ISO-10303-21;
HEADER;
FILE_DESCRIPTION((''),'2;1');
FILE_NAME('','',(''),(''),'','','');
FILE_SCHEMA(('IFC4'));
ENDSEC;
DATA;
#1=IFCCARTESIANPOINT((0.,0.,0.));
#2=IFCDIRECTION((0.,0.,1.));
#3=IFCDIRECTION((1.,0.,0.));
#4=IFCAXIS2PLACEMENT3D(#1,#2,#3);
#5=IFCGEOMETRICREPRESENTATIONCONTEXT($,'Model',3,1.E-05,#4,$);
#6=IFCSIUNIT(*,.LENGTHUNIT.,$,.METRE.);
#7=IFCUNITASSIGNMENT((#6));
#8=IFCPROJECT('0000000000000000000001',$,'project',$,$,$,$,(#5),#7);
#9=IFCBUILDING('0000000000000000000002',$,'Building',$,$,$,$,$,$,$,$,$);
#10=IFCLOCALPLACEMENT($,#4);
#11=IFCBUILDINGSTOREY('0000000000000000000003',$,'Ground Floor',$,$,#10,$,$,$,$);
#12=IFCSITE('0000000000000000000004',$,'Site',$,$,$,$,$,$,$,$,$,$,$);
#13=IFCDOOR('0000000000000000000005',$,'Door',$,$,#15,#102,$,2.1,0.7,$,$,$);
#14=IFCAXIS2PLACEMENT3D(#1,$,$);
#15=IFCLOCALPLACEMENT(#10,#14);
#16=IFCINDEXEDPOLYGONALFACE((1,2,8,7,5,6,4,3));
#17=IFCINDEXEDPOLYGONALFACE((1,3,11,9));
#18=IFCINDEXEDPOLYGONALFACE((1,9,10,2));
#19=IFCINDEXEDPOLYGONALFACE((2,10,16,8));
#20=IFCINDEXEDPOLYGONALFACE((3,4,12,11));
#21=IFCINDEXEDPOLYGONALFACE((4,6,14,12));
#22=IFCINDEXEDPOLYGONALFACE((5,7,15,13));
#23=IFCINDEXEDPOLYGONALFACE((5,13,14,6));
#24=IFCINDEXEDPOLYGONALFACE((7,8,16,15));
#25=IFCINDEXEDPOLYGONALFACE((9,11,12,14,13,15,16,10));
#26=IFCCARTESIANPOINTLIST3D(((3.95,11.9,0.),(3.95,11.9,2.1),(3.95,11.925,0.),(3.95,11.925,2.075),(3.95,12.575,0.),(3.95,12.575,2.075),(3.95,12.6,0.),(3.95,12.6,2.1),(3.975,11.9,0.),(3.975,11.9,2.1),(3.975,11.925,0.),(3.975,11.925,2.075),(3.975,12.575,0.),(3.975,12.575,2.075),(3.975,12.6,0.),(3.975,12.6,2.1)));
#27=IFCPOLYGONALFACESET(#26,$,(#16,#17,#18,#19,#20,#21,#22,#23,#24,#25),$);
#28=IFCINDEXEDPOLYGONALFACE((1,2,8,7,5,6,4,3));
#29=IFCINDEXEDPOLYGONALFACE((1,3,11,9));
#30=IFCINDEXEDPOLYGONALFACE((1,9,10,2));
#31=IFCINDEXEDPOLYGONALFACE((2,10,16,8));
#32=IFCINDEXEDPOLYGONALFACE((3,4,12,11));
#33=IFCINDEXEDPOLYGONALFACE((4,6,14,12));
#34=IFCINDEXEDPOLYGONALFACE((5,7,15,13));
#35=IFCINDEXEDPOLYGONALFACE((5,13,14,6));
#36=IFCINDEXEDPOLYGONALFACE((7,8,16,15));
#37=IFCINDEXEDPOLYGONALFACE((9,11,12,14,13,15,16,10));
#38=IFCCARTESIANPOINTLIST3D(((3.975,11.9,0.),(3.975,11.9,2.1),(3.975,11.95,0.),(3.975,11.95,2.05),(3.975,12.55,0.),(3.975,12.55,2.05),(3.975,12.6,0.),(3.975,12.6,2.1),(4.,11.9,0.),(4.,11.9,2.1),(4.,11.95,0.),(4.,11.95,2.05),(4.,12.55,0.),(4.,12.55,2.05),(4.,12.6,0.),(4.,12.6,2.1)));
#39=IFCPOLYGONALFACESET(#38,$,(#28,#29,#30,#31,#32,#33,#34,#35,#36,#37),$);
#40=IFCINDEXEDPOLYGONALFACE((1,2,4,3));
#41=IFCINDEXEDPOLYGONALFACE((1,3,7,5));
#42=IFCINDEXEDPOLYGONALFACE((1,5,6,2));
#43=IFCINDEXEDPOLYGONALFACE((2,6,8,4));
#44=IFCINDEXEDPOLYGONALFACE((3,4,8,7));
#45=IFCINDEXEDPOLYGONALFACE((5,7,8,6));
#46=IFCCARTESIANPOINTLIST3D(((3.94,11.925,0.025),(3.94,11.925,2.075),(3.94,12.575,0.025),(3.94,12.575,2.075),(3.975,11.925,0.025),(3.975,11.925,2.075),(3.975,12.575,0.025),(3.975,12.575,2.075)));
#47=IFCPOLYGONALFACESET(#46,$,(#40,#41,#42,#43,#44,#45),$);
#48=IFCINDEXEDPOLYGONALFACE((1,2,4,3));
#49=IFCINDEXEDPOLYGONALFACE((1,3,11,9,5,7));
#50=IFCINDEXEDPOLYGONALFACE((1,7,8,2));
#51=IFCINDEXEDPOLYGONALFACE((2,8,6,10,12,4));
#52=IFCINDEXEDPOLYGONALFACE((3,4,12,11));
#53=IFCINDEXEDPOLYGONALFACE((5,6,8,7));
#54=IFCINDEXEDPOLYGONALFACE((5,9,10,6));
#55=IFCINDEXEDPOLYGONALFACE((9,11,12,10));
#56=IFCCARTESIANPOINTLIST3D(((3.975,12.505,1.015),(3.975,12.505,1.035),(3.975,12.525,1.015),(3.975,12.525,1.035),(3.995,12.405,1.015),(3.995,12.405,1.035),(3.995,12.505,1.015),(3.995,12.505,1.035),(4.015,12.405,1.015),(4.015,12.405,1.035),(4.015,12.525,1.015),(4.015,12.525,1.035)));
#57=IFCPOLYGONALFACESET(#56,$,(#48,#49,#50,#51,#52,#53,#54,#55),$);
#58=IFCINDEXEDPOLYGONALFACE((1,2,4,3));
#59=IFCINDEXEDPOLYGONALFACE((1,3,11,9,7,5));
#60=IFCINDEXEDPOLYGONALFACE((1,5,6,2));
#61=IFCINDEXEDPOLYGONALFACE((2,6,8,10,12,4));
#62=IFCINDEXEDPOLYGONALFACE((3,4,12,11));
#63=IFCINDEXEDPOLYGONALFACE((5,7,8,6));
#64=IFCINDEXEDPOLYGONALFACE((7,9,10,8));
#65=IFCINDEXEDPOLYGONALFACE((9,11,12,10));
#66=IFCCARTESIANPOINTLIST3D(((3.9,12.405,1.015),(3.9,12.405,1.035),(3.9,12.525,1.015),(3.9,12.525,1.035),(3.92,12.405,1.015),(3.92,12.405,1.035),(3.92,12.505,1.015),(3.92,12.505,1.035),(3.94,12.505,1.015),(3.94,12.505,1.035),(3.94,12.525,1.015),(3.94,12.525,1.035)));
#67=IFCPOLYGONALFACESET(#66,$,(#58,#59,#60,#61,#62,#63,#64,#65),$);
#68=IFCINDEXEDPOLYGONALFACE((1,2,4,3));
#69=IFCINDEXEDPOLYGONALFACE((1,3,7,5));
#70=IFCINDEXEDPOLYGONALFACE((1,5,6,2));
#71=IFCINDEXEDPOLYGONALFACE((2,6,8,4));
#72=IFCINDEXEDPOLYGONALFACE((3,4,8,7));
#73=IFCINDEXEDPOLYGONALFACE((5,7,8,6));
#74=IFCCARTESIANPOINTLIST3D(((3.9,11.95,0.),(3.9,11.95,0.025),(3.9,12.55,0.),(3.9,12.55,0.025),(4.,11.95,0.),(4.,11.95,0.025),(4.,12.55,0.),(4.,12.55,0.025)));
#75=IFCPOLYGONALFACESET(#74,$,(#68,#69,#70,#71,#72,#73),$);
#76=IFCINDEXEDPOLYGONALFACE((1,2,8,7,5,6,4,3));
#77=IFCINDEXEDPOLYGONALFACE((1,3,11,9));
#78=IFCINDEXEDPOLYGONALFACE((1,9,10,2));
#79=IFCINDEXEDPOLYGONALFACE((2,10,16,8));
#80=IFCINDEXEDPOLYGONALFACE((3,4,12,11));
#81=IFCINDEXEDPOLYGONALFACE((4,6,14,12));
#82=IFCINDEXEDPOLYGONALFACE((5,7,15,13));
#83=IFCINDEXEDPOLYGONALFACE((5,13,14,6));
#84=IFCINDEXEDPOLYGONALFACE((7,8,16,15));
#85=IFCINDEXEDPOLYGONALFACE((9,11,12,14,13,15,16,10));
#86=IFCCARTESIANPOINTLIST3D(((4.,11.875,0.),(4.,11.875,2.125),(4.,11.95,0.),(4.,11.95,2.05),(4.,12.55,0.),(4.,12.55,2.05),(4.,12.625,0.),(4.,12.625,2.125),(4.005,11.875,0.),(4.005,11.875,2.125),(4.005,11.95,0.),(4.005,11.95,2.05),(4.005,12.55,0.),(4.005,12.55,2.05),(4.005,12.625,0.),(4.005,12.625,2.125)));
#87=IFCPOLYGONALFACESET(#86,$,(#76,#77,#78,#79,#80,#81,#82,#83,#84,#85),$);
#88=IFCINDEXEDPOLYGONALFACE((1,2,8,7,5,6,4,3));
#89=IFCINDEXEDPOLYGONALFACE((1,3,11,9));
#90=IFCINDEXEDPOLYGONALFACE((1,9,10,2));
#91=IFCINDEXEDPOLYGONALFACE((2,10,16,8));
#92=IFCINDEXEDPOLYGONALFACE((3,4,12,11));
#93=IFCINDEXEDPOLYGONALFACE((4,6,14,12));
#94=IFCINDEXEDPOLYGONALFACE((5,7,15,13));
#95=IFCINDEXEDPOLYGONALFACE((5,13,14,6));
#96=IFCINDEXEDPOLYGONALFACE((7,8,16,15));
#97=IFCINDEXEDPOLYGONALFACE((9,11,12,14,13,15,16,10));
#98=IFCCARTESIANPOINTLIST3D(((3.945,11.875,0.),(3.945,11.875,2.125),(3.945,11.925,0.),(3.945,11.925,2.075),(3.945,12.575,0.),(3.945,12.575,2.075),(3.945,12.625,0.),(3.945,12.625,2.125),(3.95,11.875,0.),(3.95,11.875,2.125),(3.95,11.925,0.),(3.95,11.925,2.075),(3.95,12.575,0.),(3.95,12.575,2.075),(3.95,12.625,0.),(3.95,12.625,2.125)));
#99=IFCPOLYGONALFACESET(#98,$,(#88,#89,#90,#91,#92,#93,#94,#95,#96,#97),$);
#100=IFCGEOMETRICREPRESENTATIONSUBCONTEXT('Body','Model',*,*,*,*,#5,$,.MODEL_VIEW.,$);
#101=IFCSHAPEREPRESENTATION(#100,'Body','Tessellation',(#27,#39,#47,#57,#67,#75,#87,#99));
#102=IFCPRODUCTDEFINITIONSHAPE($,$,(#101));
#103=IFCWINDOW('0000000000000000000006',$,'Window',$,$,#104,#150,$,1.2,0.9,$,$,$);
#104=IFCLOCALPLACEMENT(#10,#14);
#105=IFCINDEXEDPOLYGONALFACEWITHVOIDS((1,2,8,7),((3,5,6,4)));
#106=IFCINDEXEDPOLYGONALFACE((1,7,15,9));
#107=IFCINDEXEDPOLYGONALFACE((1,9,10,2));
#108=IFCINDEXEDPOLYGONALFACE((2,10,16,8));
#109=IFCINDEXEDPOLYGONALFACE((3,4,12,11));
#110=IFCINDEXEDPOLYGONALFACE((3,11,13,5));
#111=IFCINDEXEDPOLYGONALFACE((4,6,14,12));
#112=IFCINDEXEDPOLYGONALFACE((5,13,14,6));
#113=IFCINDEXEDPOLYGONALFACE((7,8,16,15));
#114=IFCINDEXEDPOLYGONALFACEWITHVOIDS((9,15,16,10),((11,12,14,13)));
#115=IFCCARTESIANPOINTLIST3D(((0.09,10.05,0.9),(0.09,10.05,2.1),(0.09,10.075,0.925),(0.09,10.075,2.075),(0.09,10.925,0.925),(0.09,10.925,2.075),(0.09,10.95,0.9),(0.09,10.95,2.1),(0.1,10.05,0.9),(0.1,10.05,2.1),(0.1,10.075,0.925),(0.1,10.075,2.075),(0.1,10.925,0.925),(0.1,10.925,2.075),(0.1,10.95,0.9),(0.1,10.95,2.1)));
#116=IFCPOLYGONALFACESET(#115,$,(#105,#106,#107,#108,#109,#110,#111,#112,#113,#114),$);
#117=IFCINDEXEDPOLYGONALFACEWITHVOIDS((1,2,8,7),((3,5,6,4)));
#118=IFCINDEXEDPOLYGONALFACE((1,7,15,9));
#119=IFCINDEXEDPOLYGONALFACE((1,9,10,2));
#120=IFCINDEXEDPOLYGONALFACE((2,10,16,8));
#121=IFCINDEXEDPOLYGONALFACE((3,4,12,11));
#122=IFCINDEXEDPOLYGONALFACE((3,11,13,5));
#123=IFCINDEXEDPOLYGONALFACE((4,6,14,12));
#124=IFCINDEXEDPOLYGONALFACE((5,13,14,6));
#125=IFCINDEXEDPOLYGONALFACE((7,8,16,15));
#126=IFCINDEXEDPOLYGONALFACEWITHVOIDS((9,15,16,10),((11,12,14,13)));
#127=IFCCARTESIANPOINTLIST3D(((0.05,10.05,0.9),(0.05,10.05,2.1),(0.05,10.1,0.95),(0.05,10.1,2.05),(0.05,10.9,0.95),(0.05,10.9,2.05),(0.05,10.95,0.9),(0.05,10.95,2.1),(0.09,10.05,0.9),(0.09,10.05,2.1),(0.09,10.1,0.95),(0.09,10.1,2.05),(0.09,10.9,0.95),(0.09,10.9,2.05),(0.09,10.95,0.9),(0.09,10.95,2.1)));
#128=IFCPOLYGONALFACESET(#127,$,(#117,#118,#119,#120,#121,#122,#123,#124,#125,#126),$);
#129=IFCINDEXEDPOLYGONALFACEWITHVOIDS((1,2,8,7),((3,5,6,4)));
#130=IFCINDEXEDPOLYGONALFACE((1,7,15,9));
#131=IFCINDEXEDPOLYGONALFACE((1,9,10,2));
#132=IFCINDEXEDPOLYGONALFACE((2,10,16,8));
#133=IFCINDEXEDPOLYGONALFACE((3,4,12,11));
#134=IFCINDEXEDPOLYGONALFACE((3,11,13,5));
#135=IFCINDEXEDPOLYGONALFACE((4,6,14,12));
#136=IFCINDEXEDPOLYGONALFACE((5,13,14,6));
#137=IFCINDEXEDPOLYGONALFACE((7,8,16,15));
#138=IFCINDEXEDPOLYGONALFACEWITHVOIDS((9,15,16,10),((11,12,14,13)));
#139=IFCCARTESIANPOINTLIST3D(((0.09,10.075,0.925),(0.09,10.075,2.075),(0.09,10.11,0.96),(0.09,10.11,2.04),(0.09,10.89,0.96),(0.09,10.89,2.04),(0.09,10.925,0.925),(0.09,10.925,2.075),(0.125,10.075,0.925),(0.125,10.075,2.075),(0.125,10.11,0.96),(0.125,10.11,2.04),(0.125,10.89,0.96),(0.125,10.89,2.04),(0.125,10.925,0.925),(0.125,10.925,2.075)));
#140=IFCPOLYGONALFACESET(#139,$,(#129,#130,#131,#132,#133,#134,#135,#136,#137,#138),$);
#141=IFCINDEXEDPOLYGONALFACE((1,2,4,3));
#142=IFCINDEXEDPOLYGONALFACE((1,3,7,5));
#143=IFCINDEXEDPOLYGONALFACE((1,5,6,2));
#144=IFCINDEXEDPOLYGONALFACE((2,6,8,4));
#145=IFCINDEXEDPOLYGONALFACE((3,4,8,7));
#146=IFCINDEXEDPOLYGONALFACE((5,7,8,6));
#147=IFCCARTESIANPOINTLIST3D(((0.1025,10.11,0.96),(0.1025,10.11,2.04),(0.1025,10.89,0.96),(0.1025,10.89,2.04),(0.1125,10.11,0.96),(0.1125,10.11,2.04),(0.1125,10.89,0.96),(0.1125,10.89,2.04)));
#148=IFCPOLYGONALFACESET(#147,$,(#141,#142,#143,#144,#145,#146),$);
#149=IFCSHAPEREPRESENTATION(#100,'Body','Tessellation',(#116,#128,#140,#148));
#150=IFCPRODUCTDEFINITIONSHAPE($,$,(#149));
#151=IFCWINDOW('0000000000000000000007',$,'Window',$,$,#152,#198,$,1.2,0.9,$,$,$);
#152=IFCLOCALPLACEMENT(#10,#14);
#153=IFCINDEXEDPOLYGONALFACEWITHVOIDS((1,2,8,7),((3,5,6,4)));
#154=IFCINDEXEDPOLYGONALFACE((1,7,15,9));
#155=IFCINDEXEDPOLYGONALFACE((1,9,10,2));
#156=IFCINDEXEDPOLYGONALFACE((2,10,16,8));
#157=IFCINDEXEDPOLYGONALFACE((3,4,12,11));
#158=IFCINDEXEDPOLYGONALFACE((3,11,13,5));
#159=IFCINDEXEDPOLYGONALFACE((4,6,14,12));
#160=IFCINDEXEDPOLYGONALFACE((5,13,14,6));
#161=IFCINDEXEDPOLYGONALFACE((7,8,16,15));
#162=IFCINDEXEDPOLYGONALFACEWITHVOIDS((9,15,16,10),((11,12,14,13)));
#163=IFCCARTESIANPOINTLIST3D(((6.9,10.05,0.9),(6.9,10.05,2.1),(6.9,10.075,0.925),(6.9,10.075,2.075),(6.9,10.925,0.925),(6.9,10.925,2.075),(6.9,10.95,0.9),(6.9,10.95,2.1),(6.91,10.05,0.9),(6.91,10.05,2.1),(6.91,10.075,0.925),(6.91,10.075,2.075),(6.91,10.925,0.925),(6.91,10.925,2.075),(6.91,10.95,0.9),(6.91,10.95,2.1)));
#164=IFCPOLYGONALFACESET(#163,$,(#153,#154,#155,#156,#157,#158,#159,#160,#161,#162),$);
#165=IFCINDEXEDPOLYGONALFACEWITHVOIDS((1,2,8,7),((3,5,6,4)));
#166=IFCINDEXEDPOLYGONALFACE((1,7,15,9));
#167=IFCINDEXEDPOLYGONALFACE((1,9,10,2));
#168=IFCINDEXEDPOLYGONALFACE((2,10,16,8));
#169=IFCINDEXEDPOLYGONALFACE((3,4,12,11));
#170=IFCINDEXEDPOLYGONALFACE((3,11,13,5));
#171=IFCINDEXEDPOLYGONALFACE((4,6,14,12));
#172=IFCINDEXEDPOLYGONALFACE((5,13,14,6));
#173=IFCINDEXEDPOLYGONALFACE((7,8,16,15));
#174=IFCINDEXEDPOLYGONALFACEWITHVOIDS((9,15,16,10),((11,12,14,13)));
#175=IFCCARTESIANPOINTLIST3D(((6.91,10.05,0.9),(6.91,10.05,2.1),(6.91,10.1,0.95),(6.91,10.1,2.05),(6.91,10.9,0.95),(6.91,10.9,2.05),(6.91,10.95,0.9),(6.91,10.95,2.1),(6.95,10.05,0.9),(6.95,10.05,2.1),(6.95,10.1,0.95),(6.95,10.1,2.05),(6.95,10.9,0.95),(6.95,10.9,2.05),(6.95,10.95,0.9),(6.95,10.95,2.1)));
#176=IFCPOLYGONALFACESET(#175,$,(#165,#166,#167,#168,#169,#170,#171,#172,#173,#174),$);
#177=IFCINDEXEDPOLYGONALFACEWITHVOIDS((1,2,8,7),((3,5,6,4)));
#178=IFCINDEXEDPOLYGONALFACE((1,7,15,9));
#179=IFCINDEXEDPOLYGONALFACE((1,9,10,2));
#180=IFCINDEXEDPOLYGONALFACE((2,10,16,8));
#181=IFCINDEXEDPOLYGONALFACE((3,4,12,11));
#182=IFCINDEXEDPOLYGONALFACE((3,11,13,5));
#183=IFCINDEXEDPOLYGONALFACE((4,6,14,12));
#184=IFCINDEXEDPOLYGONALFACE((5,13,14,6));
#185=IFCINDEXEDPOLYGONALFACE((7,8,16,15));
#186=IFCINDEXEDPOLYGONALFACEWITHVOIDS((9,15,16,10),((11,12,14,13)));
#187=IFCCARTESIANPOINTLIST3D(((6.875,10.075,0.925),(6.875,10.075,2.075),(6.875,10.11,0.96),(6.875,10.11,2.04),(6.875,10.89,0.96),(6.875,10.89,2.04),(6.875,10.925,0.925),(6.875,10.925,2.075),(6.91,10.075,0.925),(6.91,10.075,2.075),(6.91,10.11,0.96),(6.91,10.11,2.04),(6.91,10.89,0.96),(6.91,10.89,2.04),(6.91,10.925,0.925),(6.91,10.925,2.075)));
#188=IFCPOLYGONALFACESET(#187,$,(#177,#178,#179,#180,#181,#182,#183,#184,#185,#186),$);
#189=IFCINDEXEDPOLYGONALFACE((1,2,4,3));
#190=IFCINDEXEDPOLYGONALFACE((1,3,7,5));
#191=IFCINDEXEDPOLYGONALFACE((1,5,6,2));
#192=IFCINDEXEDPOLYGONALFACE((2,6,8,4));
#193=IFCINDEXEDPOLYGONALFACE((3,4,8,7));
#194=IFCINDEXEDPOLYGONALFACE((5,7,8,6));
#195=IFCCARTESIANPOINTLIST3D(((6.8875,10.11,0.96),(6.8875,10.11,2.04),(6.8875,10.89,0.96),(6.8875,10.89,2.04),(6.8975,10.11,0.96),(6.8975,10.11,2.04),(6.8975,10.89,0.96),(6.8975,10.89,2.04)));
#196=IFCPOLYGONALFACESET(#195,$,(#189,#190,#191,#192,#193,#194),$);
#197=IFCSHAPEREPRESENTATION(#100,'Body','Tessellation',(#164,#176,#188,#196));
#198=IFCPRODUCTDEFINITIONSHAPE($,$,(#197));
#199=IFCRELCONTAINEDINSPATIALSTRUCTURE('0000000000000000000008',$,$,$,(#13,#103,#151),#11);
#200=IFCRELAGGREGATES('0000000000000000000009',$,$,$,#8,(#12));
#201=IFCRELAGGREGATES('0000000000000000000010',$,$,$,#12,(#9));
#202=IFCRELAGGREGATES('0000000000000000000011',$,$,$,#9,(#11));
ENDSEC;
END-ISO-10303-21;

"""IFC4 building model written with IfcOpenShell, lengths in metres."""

from ifc_helpers import new_model, si_unit, frame, origin_with_axes, place, context, subcontext, project, spatial, line, indexed_curve, outline, extrude, element, save


model = new_model("IFC4")

# Units and contexts
model_context = context("Model", 3, precision=1e-05, world=origin_with_axes())
body_context = subcontext(model_context, "Body", "Model", "MODEL_VIEW")
ifc_project = project(units=[si_unit("LENGTHUNIT", "METRE")], contexts=[model_context])

# Site, building, storey
site = spatial("IfcSite", under=ifc_project, Name="Site")
building = spatial("IfcBuilding", under=site, Name="Building")
storey_placement = place(None, origin_with_axes())
storey = spatial("IfcBuildingStorey", under=building, at=storey_placement, Name="Ground Floor")

# Door
door_1_placement = place(storey_placement, frame((4.0, 11.9, 0.0), z_axis=(0.0, 0.0, 1.0), x_axis=(0.0, 1.0, 0.0)))
element("IfcDoor", 1, at=door_1_placement, inside=storey, Name="Door", OverallHeight=2.1, OverallWidth=0.7, context=body_context, shape_type="SweptSolid", body=[
    extrude(outline(indexed_curve([(0.0, 0.0), (0.0, 2.1), (0.7, 2.1), (0.7, 0.0), (0.675, 0.0), (0.675, 2.075), (0.025, 2.075), (0.025, 0.0)], segments=[line(1, 2, 3, 4, 5, 6, 7, 8, 1)])), frame((0.0, 0.025, 0.0), z_axis=(0.0, -1.0, 0.0), x_axis=(1.0, 0.0, 0.0)), (0.0, 0.0, -1.0), 0.025),
    extrude(outline(indexed_curve([(0.0, 0.0), (0.0, 2.1), (0.7, 2.1), (0.7, 0.0), (0.65, 0.0), (0.65, 2.05), (0.05, 2.05), (0.05, 0.0)], segments=[line(1, 2, 3, 4, 5, 6, 7, 8, 1)])), frame((0.0, 0.0, 0.0), z_axis=(0.0, -1.0, 0.0), x_axis=(1.0, 0.0, 0.0)), (0.0, 0.0, -1.0), 0.025),
    extrude(outline(indexed_curve([(0.0, 0.0), (0.65, 0.0), (0.65, 0.035), (0.0, 0.035)], segments=[line(1, 2, 3, 4, 1)])), frame((0.025, 0.025, 0.025), z_axis=(0.0, 0.0, 1.0), x_axis=(1.0, 0.0, 0.0)), (0.0, 0.0, 1.0), 2.05),
    extrude(outline(indexed_curve([(0.0, 0.0), (0.0, -0.04), (-0.12, -0.04), (-0.12, -0.02), (-0.02, -0.02), (-0.02, 0.0)], segments=[line(1, 2, 3, 4, 5, 6, 1)])), frame((0.625, 0.025, 1.015), z_axis=(0.0, 0.0, 1.0), x_axis=(1.0, 0.0, 0.0)), (0.0, 0.0, 1.0), 0.02),
    extrude(outline(indexed_curve([(0.0, 0.0), (0.0, 0.04), (-0.12, 0.04), (-0.12, 0.02), (-0.02, 0.02), (-0.02, 0.0)], segments=[line(1, 2, 3, 4, 5, 6, 1)])), frame((0.625, 0.06, 1.015), z_axis=(0.0, 0.0, 1.0), x_axis=(1.0, 0.0, 0.0)), (0.0, 0.0, 1.0), 0.02),
    extrude(outline(indexed_curve([(0.0, 0.0), (0.6, 0.0), (0.6, 0.1), (0.0, 0.1)], segments=[line(1, 2, 3, 4, 1)])), frame((0.05, 0.0, 0.0), z_axis=(0.0, 0.0, 1.0), x_axis=(1.0, 0.0, 0.0)), (0.0, 0.0, 1.0), 0.025),
    extrude(outline(indexed_curve([(0.0, 0.0), (0.0, 2.125), (0.75, 2.125), (0.75, 0.0), (0.675, 0.0), (0.675, 2.05), (0.075, 2.05), (0.075, 0.0)], segments=[line(1, 2, 3, 4, 5, 6, 7, 8, 1)])), frame((-0.025, -0.005, 0.0), z_axis=(0.0, -1.0, 0.0), x_axis=(1.0, 0.0, 0.0)), (0.0, 0.0, -1.0), 0.005),
    extrude(outline(indexed_curve([(0.0, 0.0), (0.0, 2.125), (0.75, 2.125), (0.75, 0.0), (0.7, 0.0), (0.7, 2.075), (0.05, 2.075), (0.05, 0.0)], segments=[line(1, 2, 3, 4, 5, 6, 7, 8, 1)])), frame((-0.025, 0.05, 0.0), z_axis=(0.0, -1.0, 0.0), x_axis=(1.0, 0.0, 0.0)), (0.0, 0.0, -1.0), 0.005),
])

# Windows
for number, where, z_axis, x_axis, name in (
    (2, (0.0, 10.95, 0.9), (0.0, 0.0, 1.0), (0.0, -1.0, 0.0), "Window"),
    (3, (7.0, 10.05, 0.9), (0.0, 0.0, 1.0), (0.0, 1.0, 0.0), "Window"),
):
    element("IfcWindow", number, at=place(storey_placement, frame(where, z_axis=z_axis, x_axis=x_axis)), inside=storey, Name=name, OverallHeight=1.2, OverallWidth=0.9, context=body_context, shape_type="SweptSolid", body=[
        extrude(outline(indexed_curve([(0.0, 0.0), (0.9, 0.0), (0.9, 1.2), (0.0, 1.2)], segments=[line(1, 2, 3, 4, 1)]), holes=[indexed_curve([(0.025, 0.025), (0.875, 0.025), (0.875, 1.175), (0.025, 1.175)], segments=[line(1, 2, 3, 4, 1)])]), frame((0.0, 0.09, 0.0), z_axis=(0.0, -1.0, 0.0), x_axis=(1.0, 0.0, 0.0)), (0.0, 0.0, -1.0), 0.01),
        extrude(outline(indexed_curve([(0.0, 0.0), (0.9, 0.0), (0.9, 1.2), (0.0, 1.2)], segments=[line(1, 2, 3, 4, 1)]), holes=[indexed_curve([(0.05, 0.05), (0.85, 0.05), (0.85, 1.15), (0.05, 1.15)], segments=[line(1, 2, 3, 4, 1)])]), frame((0.0, 0.05, 0.0), z_axis=(0.0, -1.0, 0.0), x_axis=(1.0, 0.0, 0.0)), (0.0, 0.0, -1.0), 0.04),
        extrude(outline(indexed_curve([(0.0, 0.0), (0.85, 0.0), (0.85, 1.15), (0.0, 1.15)], segments=[line(1, 2, 3, 4, 1)]), holes=[indexed_curve([(0.035, 0.035), (0.815, 0.035), (0.815, 1.115), (0.035, 1.115)], segments=[line(1, 2, 3, 4, 1)])]), frame((0.025, 0.09, 0.025), z_axis=(0.0, -1.0, 0.0), x_axis=(1.0, 0.0, 0.0)), (0.0, 0.0, -1.0), 0.035),
        extrude(outline(indexed_curve([(0.035, 0.035), (0.815, 0.035), (0.815, 1.115), (0.035, 1.115)], segments=[line(1, 2, 3, 4, 1)])), frame((0.025, 0.1025, 0.025), z_axis=(0.0, -1.0, 0.0), x_axis=(1.0, 0.0, 0.0)), (0.0, 0.0, -1.0), 0.01),
    ])

save(model, "model.ifc")
